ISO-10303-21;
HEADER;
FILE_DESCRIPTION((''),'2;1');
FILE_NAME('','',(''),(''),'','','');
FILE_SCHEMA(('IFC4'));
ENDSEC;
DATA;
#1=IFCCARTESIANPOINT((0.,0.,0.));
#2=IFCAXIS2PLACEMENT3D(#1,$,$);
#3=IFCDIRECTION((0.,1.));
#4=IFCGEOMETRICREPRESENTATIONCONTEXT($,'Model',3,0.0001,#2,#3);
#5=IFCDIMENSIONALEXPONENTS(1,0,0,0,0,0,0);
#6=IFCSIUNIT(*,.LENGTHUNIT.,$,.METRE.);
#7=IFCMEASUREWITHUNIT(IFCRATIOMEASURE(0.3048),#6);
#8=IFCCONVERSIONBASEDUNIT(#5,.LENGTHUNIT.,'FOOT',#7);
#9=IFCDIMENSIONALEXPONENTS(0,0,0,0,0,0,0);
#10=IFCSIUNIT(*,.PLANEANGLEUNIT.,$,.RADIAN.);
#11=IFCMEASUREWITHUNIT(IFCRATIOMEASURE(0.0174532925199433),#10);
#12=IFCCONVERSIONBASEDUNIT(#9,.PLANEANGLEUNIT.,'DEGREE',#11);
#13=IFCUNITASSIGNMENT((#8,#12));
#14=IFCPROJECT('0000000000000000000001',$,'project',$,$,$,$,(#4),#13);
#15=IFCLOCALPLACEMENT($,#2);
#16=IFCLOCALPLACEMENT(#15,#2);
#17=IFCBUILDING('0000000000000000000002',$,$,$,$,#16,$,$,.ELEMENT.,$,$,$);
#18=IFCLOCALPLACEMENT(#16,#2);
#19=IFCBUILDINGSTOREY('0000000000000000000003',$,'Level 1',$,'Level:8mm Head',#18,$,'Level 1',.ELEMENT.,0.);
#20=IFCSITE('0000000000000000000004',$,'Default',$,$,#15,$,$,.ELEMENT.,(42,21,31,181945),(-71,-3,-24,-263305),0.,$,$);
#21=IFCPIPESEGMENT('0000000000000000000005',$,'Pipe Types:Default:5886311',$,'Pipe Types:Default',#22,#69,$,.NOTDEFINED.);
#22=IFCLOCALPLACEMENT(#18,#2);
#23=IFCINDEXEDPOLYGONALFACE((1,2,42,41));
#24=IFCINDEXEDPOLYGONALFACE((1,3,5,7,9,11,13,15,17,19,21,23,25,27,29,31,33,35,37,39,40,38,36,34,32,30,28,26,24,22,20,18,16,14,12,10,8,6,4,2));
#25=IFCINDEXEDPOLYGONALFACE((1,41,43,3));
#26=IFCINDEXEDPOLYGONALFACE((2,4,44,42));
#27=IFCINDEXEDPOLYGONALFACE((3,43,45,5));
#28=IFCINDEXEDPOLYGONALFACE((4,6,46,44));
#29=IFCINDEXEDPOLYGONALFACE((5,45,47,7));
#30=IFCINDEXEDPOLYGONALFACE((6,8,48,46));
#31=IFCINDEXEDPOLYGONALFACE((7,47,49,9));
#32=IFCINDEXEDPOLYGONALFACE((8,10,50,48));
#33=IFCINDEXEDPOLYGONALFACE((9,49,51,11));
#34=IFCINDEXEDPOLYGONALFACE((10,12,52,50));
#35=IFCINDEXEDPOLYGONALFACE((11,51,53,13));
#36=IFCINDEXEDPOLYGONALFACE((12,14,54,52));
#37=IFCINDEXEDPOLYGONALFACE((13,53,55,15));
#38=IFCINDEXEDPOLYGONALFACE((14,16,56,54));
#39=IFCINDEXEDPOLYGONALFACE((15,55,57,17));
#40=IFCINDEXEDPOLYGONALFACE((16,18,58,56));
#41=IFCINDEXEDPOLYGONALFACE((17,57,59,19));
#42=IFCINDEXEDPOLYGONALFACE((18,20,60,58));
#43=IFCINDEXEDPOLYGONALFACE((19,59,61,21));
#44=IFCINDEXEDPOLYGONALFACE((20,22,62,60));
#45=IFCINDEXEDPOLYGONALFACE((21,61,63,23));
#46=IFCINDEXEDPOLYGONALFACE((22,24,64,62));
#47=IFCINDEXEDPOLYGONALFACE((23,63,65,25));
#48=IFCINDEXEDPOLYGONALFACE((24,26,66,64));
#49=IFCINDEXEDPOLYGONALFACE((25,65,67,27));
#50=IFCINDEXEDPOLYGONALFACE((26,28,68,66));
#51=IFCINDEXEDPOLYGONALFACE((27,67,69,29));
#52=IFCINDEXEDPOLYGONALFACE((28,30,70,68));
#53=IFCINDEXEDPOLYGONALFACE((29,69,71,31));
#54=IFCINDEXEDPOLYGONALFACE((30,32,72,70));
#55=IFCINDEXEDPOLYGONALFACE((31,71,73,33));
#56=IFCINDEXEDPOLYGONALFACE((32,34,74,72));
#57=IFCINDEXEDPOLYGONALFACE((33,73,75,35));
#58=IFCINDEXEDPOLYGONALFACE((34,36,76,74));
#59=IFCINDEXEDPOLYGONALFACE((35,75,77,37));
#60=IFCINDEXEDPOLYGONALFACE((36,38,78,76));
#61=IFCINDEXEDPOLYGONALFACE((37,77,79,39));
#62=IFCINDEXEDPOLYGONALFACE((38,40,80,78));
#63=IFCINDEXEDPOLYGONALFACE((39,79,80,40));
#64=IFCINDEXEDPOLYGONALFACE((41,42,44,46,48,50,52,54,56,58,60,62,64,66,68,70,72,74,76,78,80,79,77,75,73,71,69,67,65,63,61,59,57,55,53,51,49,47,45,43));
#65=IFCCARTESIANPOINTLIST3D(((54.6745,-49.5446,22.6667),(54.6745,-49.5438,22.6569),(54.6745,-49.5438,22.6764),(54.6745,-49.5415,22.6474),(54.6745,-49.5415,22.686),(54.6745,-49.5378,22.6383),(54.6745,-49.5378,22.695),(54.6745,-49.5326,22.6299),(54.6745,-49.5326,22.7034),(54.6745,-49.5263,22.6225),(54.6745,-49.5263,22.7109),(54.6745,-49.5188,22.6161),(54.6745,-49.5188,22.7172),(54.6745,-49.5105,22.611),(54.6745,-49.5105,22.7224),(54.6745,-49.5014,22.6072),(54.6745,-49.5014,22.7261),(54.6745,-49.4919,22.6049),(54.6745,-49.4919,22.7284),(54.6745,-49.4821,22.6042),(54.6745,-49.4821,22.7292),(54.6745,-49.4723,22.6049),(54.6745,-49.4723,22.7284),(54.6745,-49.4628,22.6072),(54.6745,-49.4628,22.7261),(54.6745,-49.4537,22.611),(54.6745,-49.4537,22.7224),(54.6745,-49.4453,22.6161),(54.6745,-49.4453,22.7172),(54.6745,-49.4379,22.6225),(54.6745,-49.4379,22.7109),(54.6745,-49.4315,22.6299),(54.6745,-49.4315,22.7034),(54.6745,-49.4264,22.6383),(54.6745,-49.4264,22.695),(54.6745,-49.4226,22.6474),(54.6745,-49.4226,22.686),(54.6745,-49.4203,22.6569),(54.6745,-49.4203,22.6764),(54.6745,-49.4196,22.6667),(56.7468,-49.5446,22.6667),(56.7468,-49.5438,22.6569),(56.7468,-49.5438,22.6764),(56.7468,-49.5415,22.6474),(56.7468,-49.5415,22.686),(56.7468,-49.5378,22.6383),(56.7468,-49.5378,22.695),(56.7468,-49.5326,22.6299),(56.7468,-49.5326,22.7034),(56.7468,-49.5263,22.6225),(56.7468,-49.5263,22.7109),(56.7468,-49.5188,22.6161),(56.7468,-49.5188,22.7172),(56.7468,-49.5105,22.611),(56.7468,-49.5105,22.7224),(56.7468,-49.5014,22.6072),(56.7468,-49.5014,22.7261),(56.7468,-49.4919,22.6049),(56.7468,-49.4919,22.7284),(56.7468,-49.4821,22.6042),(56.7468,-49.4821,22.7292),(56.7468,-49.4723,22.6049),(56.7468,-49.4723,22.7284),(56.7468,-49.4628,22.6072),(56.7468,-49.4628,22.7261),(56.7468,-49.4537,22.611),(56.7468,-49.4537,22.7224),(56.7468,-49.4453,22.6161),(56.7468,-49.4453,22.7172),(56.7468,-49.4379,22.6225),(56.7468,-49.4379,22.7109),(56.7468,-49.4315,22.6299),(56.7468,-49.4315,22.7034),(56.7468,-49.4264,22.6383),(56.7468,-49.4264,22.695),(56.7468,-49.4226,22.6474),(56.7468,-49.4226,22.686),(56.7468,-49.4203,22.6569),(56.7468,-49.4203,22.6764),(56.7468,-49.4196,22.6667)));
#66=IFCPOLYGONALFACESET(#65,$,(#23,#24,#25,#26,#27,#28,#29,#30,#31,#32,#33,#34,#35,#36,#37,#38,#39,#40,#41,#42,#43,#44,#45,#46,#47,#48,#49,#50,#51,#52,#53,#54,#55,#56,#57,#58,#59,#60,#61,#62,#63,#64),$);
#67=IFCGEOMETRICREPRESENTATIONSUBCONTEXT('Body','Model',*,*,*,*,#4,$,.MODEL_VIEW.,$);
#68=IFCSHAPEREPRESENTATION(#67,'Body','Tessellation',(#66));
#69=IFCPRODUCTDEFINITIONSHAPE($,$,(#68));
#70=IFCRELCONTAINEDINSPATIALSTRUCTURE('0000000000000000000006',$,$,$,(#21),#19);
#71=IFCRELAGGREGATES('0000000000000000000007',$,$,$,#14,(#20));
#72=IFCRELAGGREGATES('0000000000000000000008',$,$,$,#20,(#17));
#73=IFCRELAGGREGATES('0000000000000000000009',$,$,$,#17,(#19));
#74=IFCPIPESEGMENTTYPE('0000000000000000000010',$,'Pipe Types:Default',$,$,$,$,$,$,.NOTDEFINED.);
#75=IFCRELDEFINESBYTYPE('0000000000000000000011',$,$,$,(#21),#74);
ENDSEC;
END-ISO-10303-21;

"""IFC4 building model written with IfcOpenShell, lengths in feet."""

from ifc_helpers import new_model, entity, si_unit, converted_unit, direction, frame, origin, place, context, subcontext, project, spatial, indexed_curve, outline, extrude, type_object, element, save


model = new_model("IFC4")

# Units and contexts
model_context = context("Model", 3, precision=0.0001, world=origin(), true_north=direction((0.0, 1.0)))
body_context = subcontext(model_context, "Body", "Model", "MODEL_VIEW")
ifc_project = project(units=[converted_unit("LENGTHUNIT", "FOOT", entity("IfcRatioMeasure", 0.3048), si_unit("LENGTHUNIT", "METRE"), dimensions=[1, 0, 0, 0, 0, 0, 0]), converted_unit("PLANEANGLEUNIT", "DEGREE", entity("IfcRatioMeasure", 0.0174532925199433), si_unit("PLANEANGLEUNIT", "RADIAN"), dimensions=[0, 0, 0, 0, 0, 0, 0])], contexts=[model_context])

# Site, building, storey
site_placement = place(None, origin())
site = spatial("IfcSite", under=ifc_project, at=site_placement, Name="Default", CompositionType="ELEMENT", RefLatitude=(42, 21, 31, 181945), RefLongitude=(-71, -3, -24, -263305), RefElevation=0.0)
building_placement = place(site_placement, origin())
building = spatial("IfcBuilding", under=site, at=building_placement, CompositionType="ELEMENT")
storey_placement = place(building_placement, origin())
storey = spatial("IfcBuildingStorey", under=building, at=storey_placement, Name="Level 1", ObjectType="Level:8mm Head", LongName="Level 1", CompositionType="ELEMENT", Elevation=0.0)

# Pipe segment
pipe_segment_type = type_object("IfcPipeSegmentType", Name="Pipe Types:Default", PredefinedType="NOTDEFINED")
pipe_segment_1_placement = place(storey_placement, origin())
element("IfcPipeSegment", 1, at=pipe_segment_1_placement, inside=storey, type_object=pipe_segment_type, Name="Pipe Types:Default:5886311", ObjectType="Pipe Types:Default", PredefinedType="NOTDEFINED", context=body_context, shape_type="SweptSolid", body=[
    extrude(outline(indexed_curve([(0.0625, 0.0), (0.0617, 0.0098), (0.0594, 0.0193), (0.0557, 0.0284), (0.0506, 0.0367), (0.0442, 0.0442), (0.0367, 0.0506), (0.0284, 0.0557), (0.0193, 0.0594), (0.0098, 0.0617), (0.0, 0.0625), (-0.0098, 0.0617), (-0.0193, 0.0594), (-0.0284, 0.0557), (-0.0367, 0.0506), (-0.0442, 0.0442), (-0.0506, 0.0367), (-0.0557, 0.0284), (-0.0594, 0.0193), (-0.0617, 0.0098), (-0.0625, 0.0), (-0.0617, -0.0098), (-0.0594, -0.0193), (-0.0557, -0.0284), (-0.0506, -0.0367), (-0.0442, -0.0442), (-0.0367, -0.0506), (-0.0284, -0.0557), (-0.0193, -0.0594), (-0.0098, -0.0617), (0.0, -0.0625), (0.0098, -0.0617), (0.0193, -0.0594), (0.0284, -0.0557), (0.0367, -0.0506), (0.0442, -0.0442), (0.0506, -0.0367), (0.0557, -0.0284), (0.0594, -0.0193), (0.0617, -0.0098), (0.0625, 0.0)], self_intersect=False)), frame((54.6745, -49.4821, 22.6667), z_axis=(1.0, 0.0, 0.0), x_axis=(0.0, 1.0, 0.0)), (0.0, 0.0, 1.0), 2.0723),
])

save(model, "model.ifc")
